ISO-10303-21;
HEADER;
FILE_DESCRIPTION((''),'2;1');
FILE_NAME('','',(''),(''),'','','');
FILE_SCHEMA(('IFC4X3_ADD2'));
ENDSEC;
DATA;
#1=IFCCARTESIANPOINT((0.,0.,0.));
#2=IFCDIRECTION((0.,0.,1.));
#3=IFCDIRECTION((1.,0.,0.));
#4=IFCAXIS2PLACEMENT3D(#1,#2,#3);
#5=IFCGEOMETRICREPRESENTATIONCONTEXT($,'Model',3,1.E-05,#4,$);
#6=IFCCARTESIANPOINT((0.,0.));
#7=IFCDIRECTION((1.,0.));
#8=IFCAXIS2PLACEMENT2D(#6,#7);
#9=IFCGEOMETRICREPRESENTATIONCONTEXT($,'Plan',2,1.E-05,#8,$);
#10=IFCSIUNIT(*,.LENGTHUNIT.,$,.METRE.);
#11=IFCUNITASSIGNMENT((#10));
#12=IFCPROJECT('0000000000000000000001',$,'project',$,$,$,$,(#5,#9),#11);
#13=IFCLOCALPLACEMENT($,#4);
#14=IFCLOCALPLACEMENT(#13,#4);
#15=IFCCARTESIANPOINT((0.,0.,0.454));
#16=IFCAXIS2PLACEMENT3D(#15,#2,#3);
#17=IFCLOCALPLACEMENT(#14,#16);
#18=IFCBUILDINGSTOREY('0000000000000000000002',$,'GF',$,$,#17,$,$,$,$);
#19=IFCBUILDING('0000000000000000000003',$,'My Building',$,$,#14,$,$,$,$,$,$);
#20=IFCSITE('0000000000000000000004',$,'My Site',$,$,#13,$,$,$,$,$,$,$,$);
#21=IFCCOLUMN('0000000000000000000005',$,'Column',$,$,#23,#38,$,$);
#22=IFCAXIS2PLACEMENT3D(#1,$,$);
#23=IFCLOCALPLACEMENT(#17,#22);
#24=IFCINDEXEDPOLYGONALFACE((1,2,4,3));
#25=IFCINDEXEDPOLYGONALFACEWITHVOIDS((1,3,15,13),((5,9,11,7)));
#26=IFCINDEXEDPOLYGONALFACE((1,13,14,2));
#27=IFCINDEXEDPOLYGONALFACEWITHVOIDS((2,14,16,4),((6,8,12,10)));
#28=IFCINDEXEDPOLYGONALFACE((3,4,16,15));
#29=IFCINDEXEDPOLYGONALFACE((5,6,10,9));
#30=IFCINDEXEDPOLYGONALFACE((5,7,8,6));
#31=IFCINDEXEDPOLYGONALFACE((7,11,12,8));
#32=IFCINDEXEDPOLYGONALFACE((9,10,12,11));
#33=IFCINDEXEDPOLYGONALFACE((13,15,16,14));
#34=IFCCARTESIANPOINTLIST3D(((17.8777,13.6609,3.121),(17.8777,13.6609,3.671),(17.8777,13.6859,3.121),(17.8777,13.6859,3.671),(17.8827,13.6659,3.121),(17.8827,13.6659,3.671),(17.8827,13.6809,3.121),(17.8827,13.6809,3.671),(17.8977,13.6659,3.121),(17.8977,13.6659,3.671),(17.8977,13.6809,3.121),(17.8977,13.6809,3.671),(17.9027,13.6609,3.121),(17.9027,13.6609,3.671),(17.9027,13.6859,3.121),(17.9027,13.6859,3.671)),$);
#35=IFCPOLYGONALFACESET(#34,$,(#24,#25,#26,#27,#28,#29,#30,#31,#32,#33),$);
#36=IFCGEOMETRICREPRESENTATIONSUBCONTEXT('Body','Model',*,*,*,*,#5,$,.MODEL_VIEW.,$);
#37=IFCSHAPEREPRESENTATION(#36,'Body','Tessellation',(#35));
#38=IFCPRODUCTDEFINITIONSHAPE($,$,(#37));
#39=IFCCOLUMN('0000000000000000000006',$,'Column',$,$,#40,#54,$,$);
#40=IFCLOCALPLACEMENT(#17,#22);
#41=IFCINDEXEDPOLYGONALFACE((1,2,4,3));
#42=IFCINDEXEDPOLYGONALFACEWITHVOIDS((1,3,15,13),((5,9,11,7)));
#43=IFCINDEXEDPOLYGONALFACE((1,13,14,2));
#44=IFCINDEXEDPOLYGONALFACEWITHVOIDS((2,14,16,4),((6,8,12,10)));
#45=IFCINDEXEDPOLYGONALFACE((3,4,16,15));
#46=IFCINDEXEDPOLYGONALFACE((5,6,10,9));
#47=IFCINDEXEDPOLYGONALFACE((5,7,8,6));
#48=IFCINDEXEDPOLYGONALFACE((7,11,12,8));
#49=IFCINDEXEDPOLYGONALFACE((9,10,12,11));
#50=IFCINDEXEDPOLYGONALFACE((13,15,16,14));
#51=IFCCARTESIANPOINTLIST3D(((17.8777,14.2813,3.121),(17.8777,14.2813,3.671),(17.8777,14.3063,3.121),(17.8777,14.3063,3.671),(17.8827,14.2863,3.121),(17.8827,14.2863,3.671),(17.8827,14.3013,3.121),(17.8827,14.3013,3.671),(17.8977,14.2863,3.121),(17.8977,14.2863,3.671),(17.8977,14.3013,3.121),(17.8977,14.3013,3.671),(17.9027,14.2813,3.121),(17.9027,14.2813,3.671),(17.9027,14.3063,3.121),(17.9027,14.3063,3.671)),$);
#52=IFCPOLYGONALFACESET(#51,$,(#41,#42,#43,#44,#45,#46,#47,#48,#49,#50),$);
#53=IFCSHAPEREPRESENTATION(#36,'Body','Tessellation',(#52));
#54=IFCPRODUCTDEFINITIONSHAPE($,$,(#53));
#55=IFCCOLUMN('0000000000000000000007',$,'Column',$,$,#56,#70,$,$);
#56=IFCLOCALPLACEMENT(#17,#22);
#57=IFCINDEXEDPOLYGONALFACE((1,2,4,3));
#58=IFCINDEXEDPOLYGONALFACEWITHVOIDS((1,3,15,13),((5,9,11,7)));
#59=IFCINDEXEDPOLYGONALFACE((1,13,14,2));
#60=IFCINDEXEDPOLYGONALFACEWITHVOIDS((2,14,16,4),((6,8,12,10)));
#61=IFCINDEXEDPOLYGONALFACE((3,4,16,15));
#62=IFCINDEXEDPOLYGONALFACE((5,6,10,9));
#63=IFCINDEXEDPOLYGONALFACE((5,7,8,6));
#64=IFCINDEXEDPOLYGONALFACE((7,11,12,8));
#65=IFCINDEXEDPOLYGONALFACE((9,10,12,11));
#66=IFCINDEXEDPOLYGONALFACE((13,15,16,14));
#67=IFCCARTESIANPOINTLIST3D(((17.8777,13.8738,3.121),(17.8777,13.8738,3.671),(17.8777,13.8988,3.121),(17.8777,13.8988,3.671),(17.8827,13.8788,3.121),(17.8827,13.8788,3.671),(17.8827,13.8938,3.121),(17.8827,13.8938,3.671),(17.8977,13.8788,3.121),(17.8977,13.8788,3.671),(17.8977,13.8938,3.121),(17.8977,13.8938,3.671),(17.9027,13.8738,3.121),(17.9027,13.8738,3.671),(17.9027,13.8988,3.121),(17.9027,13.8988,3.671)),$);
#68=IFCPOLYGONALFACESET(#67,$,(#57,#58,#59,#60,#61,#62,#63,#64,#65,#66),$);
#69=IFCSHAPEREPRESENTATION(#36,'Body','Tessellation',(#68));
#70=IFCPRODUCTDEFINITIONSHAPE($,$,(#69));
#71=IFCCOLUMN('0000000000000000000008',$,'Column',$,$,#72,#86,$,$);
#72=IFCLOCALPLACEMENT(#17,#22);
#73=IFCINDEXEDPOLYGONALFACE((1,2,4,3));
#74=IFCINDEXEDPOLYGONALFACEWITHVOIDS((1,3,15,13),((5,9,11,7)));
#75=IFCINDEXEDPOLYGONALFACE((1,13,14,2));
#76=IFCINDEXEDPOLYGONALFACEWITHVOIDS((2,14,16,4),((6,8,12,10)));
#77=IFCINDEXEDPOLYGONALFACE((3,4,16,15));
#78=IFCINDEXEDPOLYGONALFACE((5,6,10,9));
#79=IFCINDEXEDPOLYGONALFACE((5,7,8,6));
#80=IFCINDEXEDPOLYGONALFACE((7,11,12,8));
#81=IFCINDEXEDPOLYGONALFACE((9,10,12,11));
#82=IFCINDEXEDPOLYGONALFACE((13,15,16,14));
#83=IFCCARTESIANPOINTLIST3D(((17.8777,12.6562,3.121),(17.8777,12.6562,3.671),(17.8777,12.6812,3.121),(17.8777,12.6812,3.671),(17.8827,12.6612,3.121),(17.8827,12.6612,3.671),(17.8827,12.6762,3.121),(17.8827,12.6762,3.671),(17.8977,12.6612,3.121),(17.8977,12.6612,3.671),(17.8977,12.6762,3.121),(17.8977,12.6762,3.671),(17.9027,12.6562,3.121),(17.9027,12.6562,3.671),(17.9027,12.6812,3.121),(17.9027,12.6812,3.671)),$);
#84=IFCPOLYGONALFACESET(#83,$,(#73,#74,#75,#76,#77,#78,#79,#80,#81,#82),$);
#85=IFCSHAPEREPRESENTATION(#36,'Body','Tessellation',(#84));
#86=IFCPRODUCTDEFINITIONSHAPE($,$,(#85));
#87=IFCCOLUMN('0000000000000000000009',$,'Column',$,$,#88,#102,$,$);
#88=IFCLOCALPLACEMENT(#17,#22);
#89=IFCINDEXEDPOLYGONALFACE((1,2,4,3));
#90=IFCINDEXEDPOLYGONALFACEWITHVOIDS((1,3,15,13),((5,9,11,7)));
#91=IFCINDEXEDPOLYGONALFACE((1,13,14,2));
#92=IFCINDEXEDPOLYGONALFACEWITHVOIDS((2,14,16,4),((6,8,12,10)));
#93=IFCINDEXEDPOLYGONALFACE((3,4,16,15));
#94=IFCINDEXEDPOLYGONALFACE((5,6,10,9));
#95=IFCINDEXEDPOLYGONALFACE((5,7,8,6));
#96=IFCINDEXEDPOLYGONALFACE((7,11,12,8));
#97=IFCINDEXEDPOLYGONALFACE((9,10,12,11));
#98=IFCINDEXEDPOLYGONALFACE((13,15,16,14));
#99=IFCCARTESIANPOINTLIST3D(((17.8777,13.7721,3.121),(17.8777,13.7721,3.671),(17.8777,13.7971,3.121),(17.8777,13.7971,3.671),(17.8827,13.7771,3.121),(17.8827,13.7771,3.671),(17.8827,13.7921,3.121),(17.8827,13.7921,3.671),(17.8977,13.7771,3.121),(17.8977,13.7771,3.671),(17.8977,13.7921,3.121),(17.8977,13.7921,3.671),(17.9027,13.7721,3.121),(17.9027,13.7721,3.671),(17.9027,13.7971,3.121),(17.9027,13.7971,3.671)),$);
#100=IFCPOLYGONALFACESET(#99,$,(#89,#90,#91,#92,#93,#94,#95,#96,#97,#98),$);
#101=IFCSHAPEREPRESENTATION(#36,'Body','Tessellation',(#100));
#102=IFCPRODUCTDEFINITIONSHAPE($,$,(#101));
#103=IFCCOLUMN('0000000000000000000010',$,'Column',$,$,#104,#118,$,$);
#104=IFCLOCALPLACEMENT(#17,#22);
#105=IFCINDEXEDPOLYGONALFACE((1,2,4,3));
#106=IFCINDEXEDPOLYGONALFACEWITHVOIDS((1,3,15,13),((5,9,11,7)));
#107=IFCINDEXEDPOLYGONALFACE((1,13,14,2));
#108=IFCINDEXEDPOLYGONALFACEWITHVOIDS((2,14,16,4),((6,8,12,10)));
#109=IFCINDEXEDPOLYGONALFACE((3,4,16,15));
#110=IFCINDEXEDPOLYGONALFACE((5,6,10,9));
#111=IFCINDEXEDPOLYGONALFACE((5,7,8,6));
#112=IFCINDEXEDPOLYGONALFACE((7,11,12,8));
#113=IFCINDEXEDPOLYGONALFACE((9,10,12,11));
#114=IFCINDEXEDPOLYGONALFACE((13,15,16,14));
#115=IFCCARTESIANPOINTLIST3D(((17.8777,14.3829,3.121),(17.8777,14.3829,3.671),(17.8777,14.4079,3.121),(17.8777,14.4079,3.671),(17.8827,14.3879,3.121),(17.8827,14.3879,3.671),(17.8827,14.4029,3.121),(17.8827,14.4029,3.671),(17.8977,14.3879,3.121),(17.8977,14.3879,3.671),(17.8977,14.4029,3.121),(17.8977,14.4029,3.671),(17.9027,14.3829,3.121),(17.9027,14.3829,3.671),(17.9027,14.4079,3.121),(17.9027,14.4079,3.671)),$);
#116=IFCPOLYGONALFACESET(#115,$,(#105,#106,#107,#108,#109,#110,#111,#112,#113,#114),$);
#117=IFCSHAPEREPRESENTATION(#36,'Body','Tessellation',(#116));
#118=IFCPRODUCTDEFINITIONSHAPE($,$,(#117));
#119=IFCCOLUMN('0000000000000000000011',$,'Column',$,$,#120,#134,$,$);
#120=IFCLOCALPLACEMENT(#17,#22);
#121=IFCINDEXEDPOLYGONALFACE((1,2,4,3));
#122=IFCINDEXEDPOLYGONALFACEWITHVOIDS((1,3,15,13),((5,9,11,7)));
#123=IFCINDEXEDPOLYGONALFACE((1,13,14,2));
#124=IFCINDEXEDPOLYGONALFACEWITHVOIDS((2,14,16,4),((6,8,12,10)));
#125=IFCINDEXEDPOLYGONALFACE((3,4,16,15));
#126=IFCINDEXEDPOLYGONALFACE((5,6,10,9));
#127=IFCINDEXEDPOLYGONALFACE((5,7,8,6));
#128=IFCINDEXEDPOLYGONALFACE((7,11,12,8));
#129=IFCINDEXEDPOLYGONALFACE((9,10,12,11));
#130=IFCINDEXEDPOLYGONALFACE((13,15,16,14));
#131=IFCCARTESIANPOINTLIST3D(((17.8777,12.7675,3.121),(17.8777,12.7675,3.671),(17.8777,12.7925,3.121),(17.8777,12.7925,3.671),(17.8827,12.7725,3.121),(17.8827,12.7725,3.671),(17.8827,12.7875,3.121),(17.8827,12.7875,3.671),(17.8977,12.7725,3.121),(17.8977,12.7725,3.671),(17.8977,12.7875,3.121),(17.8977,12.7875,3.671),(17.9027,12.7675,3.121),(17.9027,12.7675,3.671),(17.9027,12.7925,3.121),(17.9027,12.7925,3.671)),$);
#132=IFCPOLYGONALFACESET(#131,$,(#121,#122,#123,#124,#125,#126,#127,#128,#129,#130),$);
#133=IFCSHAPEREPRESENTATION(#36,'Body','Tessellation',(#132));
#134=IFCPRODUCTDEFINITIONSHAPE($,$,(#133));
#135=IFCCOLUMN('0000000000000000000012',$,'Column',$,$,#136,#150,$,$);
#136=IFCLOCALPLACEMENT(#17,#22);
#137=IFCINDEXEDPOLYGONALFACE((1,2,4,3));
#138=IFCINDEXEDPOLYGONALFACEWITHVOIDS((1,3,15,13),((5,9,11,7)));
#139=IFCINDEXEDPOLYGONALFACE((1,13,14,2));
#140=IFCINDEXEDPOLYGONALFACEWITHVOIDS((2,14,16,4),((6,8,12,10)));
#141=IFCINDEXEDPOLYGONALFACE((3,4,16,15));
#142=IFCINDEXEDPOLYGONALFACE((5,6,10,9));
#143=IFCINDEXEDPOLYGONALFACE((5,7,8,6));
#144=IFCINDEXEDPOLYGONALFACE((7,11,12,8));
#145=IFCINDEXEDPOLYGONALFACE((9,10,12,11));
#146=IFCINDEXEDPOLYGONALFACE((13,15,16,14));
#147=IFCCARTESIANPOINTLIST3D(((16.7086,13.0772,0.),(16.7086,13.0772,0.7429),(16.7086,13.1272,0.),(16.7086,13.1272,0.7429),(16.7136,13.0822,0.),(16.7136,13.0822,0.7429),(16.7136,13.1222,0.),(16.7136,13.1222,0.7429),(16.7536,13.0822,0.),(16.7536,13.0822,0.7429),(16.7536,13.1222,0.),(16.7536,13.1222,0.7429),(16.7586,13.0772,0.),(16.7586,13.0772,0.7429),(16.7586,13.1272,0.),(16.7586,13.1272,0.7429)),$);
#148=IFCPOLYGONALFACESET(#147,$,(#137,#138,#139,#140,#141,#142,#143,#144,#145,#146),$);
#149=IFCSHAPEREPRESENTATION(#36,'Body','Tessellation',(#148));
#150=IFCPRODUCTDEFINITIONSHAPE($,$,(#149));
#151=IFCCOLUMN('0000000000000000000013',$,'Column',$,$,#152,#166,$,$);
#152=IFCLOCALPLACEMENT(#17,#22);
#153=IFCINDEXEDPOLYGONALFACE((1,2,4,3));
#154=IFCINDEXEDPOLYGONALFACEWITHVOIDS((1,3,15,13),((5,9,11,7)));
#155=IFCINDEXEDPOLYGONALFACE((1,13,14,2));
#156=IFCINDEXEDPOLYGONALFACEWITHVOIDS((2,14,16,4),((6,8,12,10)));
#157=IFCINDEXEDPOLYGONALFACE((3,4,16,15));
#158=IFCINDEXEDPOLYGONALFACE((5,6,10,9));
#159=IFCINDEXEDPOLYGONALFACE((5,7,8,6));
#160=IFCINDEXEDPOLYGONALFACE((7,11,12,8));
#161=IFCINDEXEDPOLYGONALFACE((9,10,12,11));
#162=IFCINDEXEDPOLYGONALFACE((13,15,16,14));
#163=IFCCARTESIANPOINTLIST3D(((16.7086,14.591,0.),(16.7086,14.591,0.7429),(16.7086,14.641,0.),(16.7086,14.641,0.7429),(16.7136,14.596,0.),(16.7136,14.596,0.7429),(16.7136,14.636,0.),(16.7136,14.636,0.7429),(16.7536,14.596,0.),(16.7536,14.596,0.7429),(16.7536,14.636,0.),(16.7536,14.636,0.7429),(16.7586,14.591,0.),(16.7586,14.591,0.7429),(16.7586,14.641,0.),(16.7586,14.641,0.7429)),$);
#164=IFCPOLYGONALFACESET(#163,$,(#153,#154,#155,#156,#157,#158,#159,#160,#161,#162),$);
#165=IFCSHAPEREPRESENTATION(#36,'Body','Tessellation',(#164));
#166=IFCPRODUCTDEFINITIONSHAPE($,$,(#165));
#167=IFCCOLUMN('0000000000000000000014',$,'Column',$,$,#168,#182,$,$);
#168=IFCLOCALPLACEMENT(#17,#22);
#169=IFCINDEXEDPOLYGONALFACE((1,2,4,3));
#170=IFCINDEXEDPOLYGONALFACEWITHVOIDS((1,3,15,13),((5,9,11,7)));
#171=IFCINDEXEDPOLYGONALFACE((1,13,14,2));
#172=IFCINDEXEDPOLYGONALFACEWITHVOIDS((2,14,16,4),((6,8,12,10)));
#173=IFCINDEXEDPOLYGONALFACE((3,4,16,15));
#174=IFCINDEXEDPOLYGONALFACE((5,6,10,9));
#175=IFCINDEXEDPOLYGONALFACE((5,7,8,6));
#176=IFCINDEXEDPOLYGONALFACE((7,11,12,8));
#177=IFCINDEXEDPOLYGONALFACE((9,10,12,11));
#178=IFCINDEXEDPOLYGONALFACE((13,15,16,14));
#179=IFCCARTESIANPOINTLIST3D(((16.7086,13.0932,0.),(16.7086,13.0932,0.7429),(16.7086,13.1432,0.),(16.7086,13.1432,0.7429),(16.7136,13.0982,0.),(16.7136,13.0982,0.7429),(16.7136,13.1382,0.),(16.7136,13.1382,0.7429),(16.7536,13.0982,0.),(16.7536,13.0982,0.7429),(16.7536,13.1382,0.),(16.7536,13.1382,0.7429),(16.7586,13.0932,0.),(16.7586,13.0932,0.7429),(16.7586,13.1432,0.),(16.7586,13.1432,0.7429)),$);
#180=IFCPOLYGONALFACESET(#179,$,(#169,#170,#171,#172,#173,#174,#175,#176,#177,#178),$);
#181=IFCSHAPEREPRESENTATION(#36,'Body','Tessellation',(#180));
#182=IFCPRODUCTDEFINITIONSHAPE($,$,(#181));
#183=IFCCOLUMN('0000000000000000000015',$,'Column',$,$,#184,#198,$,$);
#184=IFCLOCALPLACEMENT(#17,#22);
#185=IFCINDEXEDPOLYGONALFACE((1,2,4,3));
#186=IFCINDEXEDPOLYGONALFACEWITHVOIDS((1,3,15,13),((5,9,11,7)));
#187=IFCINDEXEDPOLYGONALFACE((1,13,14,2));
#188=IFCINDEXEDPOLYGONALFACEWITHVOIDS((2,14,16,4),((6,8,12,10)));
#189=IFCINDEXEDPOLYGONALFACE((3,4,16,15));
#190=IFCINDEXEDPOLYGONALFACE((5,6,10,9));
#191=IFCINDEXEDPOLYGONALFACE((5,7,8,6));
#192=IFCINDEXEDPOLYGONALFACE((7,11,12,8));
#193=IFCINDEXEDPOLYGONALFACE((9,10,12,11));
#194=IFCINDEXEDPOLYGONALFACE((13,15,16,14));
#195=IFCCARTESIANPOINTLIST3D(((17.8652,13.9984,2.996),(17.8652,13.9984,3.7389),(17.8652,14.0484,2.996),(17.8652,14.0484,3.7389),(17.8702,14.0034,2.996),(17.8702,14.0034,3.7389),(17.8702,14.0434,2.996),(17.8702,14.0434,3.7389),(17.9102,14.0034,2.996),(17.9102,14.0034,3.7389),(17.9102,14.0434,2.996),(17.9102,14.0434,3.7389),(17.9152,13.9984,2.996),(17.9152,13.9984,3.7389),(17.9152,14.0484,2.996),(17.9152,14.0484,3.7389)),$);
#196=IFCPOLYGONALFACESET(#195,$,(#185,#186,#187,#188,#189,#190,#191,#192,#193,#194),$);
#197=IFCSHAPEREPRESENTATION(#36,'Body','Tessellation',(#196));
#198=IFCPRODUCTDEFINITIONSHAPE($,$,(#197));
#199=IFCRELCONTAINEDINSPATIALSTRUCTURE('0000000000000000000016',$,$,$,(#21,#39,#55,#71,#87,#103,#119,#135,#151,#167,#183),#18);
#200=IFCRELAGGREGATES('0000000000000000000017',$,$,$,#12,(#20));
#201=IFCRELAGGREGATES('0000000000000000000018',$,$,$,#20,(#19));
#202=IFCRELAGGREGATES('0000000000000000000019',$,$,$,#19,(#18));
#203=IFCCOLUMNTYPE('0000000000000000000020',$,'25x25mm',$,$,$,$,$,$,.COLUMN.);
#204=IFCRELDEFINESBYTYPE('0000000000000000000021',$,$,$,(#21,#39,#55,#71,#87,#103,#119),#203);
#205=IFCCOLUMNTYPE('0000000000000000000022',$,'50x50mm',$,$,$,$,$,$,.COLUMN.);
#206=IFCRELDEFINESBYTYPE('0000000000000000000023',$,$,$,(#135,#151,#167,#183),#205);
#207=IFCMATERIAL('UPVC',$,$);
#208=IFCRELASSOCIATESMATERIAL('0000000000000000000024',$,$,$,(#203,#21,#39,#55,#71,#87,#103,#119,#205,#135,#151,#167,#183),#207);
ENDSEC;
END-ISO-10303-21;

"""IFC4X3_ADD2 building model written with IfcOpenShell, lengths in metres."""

from ifc_helpers import new_model, si_unit, frame, origin_with_axes, origin_2d_with_axis, place, context, subcontext, project, spatial, hollow_rectangle, extrude, material, material_profile, profile_set, profile_usage, type_object, element, save


model = new_model("IFC4X3_ADD2")

# Units and contexts
model_context = context("Model", 3, precision=1e-05, world=origin_with_axes())
plan_context = context("Plan", 2, precision=1e-05, world=origin_2d_with_axis())
body_context = subcontext(model_context, "Body", "Model", "MODEL_VIEW")
ifc_project = project(units=[si_unit("LENGTHUNIT", "METRE")], contexts=[model_context, plan_context])

# Site, building, storey
site_placement = place(None, origin_with_axes())
site = spatial("IfcSite", under=ifc_project, at=site_placement, Name="My Site")
building_placement = place(site_placement, origin_with_axes())
building = spatial("IfcBuilding", under=site, at=building_placement, Name="My Building")
storey_placement = place(building_placement, frame((0.0, 0.0, 0.454), z_axis=(0.0, 0.0, 1.0), x_axis=(1.0, 0.0, 0.0)))
storey = spatial("IfcBuildingStorey", under=building, at=storey_placement, Name="GF")

# Columns
ifc_material = material(Name="UPVC")
ifc_material_profile_1 = material_profile(ifc_material, hollow_rectangle(XDim=0.025, YDim=0.025, WallThickness=0.005))
ifc_profile_set_1 = profile_set([ifc_material_profile_1])
column_type_1 = type_object("IfcColumnType", Name="25x25mm", PredefinedType="COLUMN", material=ifc_profile_set_1)
ifc_profile_usage_1 = profile_usage(ifc_profile_set_1)
column_1_placement = place(storey_placement, frame((17.8902, 13.6734, 3.121), z_axis=(0.0, 0.0, 1.0), x_axis=(0.0, -1.0, 0.0)))
element("IfcColumn", 1, at=column_1_placement, inside=storey, type_object=column_type_1, material=ifc_profile_usage_1, Name="Column", context=body_context, shape_type="SweptSolid", body=[
    extrude(hollow_rectangle(XDim=0.025, YDim=0.025, WallThickness=0.005), origin_with_axes(), (0.0, 0.0, 1.0), 0.55),
])
ifc_profile_usage_2 = profile_usage(ifc_profile_set_1)
column_2_placement = place(storey_placement, frame((17.8902, 14.2938, 3.121), z_axis=(0.0, 0.0, 1.0), x_axis=(0.0, -1.0, 0.0)))
element("IfcColumn", 2, at=column_2_placement, inside=storey, type_object=column_type_1, material=ifc_profile_usage_2, Name="Column", context=body_context, shape_type="SweptSolid", body=[
    extrude(hollow_rectangle(XDim=0.025, YDim=0.025, WallThickness=0.005), origin_with_axes(), (0.0, 0.0, 1.0), 0.55),
])
ifc_profile_usage_3 = profile_usage(ifc_profile_set_1)
column_3_placement = place(storey_placement, frame((17.8902, 13.8863, 3.121), z_axis=(0.0, 0.0, 1.0), x_axis=(0.0, -1.0, 0.0)))
element("IfcColumn", 3, at=column_3_placement, inside=storey, type_object=column_type_1, material=ifc_profile_usage_3, Name="Column", context=body_context, shape_type="SweptSolid", body=[
    extrude(hollow_rectangle(XDim=0.025, YDim=0.025, WallThickness=0.005), origin_with_axes(), (0.0, 0.0, 1.0), 0.55),
])
ifc_profile_usage_4 = profile_usage(ifc_profile_set_1)
column_4_placement = place(storey_placement, frame((17.8902, 12.6687, 3.121), z_axis=(0.0, 0.0, 1.0), x_axis=(0.0, -1.0, 0.0)))
element("IfcColumn", 4, at=column_4_placement, inside=storey, type_object=column_type_1, material=ifc_profile_usage_4, Name="Column", context=body_context, shape_type="SweptSolid", body=[
    extrude(hollow_rectangle(XDim=0.025, YDim=0.025, WallThickness=0.005), origin_with_axes(), (0.0, 0.0, 1.0), 0.55),
])
ifc_profile_usage_5 = profile_usage(ifc_profile_set_1)
column_5_placement = place(storey_placement, frame((17.8902, 13.7846, 3.121), z_axis=(0.0, 0.0, 1.0), x_axis=(0.0, -1.0, 0.0)))
element("IfcColumn", 5, at=column_5_placement, inside=storey, type_object=column_type_1, material=ifc_profile_usage_5, Name="Column", context=body_context, shape_type="SweptSolid", body=[
    extrude(hollow_rectangle(XDim=0.025, YDim=0.025, WallThickness=0.005), origin_with_axes(), (0.0, 0.0, 1.0), 0.55),
])
ifc_profile_usage_6 = profile_usage(ifc_profile_set_1)
column_6_placement = place(storey_placement, frame((17.8902, 14.3954, 3.121), z_axis=(0.0, 0.0, 1.0), x_axis=(0.0, -1.0, 0.0)))
element("IfcColumn", 6, at=column_6_placement, inside=storey, type_object=column_type_1, material=ifc_profile_usage_6, Name="Column", context=body_context, shape_type="SweptSolid", body=[
    extrude(hollow_rectangle(XDim=0.025, YDim=0.025, WallThickness=0.005), origin_with_axes(), (0.0, 0.0, 1.0), 0.55),
])
ifc_profile_usage_7 = profile_usage(ifc_profile_set_1)
column_7_placement = place(storey_placement, frame((17.8902, 12.78, 3.121), z_axis=(0.0, 0.0, 1.0), x_axis=(0.0, -1.0, 0.0)))
element("IfcColumn", 7, at=column_7_placement, inside=storey, type_object=column_type_1, material=ifc_profile_usage_7, Name="Column", context=body_context, shape_type="SweptSolid", body=[
    extrude(hollow_rectangle(XDim=0.025, YDim=0.025, WallThickness=0.005), origin_with_axes(), (0.0, 0.0, 1.0), 0.55),
])
ifc_material_profile_2 = material_profile(ifc_material, hollow_rectangle(XDim=0.05, YDim=0.05, WallThickness=0.005))
ifc_profile_set_2 = profile_set([ifc_material_profile_2])
ifc_profile_usage_8 = profile_usage(ifc_profile_set_2)
column_type_2 = type_object("IfcColumnType", Name="50x50mm", PredefinedType="COLUMN", material=ifc_profile_set_2)
column_8_placement = place(storey_placement, frame((16.7336, 13.1022, 0.0), z_axis=(0.0, 0.0, 1.0), x_axis=(0.0, -1.0, 0.0)))
element("IfcColumn", 8, at=column_8_placement, inside=storey, type_object=column_type_2, material=ifc_profile_usage_8, Name="Column", context=body_context, shape_type="SweptSolid", body=[
    extrude(hollow_rectangle(XDim=0.05, YDim=0.05, WallThickness=0.005), origin_with_axes(), (0.0, 0.0, 1.0), 0.7429),
])
ifc_profile_usage_9 = profile_usage(ifc_profile_set_2)
column_9_placement = place(storey_placement, frame((16.7336, 14.616, 0.0), z_axis=(0.0, 0.0, 1.0), x_axis=(0.0, -1.0, 0.0)))
element("IfcColumn", 9, at=column_9_placement, inside=storey, type_object=column_type_2, material=ifc_profile_usage_9, Name="Column", context=body_context, shape_type="SweptSolid", body=[
    extrude(hollow_rectangle(XDim=0.05, YDim=0.05, WallThickness=0.005), origin_with_axes(), (0.0, 0.0, 1.0), 0.7429),
])
ifc_profile_usage_10 = profile_usage(ifc_profile_set_2)
column_10_placement = place(storey_placement, frame((16.7336, 13.1182, 0.0), z_axis=(0.0, 0.0, 1.0), x_axis=(0.0, -1.0, 0.0)))
element("IfcColumn", 10, at=column_10_placement, inside=storey, type_object=column_type_2, material=ifc_profile_usage_10, Name="Column", context=body_context, shape_type="SweptSolid", body=[
    extrude(hollow_rectangle(XDim=0.05, YDim=0.05, WallThickness=0.005), origin_with_axes(), (0.0, 0.0, 1.0), 0.7429),
])
ifc_profile_usage_11 = profile_usage(ifc_profile_set_2)
column_11_placement = place(storey_placement, frame((17.8902, 14.0234, 2.996), z_axis=(0.0, 0.0, 1.0), x_axis=(0.0, -1.0, 0.0)))
element("IfcColumn", 11, at=column_11_placement, inside=storey, type_object=column_type_2, material=ifc_profile_usage_11, Name="Column", context=body_context, shape_type="SweptSolid", body=[
    extrude(hollow_rectangle(XDim=0.05, YDim=0.05, WallThickness=0.005), origin_with_axes(), (0.0, 0.0, 1.0), 0.7429),
])

save(model, "model.ifc")
